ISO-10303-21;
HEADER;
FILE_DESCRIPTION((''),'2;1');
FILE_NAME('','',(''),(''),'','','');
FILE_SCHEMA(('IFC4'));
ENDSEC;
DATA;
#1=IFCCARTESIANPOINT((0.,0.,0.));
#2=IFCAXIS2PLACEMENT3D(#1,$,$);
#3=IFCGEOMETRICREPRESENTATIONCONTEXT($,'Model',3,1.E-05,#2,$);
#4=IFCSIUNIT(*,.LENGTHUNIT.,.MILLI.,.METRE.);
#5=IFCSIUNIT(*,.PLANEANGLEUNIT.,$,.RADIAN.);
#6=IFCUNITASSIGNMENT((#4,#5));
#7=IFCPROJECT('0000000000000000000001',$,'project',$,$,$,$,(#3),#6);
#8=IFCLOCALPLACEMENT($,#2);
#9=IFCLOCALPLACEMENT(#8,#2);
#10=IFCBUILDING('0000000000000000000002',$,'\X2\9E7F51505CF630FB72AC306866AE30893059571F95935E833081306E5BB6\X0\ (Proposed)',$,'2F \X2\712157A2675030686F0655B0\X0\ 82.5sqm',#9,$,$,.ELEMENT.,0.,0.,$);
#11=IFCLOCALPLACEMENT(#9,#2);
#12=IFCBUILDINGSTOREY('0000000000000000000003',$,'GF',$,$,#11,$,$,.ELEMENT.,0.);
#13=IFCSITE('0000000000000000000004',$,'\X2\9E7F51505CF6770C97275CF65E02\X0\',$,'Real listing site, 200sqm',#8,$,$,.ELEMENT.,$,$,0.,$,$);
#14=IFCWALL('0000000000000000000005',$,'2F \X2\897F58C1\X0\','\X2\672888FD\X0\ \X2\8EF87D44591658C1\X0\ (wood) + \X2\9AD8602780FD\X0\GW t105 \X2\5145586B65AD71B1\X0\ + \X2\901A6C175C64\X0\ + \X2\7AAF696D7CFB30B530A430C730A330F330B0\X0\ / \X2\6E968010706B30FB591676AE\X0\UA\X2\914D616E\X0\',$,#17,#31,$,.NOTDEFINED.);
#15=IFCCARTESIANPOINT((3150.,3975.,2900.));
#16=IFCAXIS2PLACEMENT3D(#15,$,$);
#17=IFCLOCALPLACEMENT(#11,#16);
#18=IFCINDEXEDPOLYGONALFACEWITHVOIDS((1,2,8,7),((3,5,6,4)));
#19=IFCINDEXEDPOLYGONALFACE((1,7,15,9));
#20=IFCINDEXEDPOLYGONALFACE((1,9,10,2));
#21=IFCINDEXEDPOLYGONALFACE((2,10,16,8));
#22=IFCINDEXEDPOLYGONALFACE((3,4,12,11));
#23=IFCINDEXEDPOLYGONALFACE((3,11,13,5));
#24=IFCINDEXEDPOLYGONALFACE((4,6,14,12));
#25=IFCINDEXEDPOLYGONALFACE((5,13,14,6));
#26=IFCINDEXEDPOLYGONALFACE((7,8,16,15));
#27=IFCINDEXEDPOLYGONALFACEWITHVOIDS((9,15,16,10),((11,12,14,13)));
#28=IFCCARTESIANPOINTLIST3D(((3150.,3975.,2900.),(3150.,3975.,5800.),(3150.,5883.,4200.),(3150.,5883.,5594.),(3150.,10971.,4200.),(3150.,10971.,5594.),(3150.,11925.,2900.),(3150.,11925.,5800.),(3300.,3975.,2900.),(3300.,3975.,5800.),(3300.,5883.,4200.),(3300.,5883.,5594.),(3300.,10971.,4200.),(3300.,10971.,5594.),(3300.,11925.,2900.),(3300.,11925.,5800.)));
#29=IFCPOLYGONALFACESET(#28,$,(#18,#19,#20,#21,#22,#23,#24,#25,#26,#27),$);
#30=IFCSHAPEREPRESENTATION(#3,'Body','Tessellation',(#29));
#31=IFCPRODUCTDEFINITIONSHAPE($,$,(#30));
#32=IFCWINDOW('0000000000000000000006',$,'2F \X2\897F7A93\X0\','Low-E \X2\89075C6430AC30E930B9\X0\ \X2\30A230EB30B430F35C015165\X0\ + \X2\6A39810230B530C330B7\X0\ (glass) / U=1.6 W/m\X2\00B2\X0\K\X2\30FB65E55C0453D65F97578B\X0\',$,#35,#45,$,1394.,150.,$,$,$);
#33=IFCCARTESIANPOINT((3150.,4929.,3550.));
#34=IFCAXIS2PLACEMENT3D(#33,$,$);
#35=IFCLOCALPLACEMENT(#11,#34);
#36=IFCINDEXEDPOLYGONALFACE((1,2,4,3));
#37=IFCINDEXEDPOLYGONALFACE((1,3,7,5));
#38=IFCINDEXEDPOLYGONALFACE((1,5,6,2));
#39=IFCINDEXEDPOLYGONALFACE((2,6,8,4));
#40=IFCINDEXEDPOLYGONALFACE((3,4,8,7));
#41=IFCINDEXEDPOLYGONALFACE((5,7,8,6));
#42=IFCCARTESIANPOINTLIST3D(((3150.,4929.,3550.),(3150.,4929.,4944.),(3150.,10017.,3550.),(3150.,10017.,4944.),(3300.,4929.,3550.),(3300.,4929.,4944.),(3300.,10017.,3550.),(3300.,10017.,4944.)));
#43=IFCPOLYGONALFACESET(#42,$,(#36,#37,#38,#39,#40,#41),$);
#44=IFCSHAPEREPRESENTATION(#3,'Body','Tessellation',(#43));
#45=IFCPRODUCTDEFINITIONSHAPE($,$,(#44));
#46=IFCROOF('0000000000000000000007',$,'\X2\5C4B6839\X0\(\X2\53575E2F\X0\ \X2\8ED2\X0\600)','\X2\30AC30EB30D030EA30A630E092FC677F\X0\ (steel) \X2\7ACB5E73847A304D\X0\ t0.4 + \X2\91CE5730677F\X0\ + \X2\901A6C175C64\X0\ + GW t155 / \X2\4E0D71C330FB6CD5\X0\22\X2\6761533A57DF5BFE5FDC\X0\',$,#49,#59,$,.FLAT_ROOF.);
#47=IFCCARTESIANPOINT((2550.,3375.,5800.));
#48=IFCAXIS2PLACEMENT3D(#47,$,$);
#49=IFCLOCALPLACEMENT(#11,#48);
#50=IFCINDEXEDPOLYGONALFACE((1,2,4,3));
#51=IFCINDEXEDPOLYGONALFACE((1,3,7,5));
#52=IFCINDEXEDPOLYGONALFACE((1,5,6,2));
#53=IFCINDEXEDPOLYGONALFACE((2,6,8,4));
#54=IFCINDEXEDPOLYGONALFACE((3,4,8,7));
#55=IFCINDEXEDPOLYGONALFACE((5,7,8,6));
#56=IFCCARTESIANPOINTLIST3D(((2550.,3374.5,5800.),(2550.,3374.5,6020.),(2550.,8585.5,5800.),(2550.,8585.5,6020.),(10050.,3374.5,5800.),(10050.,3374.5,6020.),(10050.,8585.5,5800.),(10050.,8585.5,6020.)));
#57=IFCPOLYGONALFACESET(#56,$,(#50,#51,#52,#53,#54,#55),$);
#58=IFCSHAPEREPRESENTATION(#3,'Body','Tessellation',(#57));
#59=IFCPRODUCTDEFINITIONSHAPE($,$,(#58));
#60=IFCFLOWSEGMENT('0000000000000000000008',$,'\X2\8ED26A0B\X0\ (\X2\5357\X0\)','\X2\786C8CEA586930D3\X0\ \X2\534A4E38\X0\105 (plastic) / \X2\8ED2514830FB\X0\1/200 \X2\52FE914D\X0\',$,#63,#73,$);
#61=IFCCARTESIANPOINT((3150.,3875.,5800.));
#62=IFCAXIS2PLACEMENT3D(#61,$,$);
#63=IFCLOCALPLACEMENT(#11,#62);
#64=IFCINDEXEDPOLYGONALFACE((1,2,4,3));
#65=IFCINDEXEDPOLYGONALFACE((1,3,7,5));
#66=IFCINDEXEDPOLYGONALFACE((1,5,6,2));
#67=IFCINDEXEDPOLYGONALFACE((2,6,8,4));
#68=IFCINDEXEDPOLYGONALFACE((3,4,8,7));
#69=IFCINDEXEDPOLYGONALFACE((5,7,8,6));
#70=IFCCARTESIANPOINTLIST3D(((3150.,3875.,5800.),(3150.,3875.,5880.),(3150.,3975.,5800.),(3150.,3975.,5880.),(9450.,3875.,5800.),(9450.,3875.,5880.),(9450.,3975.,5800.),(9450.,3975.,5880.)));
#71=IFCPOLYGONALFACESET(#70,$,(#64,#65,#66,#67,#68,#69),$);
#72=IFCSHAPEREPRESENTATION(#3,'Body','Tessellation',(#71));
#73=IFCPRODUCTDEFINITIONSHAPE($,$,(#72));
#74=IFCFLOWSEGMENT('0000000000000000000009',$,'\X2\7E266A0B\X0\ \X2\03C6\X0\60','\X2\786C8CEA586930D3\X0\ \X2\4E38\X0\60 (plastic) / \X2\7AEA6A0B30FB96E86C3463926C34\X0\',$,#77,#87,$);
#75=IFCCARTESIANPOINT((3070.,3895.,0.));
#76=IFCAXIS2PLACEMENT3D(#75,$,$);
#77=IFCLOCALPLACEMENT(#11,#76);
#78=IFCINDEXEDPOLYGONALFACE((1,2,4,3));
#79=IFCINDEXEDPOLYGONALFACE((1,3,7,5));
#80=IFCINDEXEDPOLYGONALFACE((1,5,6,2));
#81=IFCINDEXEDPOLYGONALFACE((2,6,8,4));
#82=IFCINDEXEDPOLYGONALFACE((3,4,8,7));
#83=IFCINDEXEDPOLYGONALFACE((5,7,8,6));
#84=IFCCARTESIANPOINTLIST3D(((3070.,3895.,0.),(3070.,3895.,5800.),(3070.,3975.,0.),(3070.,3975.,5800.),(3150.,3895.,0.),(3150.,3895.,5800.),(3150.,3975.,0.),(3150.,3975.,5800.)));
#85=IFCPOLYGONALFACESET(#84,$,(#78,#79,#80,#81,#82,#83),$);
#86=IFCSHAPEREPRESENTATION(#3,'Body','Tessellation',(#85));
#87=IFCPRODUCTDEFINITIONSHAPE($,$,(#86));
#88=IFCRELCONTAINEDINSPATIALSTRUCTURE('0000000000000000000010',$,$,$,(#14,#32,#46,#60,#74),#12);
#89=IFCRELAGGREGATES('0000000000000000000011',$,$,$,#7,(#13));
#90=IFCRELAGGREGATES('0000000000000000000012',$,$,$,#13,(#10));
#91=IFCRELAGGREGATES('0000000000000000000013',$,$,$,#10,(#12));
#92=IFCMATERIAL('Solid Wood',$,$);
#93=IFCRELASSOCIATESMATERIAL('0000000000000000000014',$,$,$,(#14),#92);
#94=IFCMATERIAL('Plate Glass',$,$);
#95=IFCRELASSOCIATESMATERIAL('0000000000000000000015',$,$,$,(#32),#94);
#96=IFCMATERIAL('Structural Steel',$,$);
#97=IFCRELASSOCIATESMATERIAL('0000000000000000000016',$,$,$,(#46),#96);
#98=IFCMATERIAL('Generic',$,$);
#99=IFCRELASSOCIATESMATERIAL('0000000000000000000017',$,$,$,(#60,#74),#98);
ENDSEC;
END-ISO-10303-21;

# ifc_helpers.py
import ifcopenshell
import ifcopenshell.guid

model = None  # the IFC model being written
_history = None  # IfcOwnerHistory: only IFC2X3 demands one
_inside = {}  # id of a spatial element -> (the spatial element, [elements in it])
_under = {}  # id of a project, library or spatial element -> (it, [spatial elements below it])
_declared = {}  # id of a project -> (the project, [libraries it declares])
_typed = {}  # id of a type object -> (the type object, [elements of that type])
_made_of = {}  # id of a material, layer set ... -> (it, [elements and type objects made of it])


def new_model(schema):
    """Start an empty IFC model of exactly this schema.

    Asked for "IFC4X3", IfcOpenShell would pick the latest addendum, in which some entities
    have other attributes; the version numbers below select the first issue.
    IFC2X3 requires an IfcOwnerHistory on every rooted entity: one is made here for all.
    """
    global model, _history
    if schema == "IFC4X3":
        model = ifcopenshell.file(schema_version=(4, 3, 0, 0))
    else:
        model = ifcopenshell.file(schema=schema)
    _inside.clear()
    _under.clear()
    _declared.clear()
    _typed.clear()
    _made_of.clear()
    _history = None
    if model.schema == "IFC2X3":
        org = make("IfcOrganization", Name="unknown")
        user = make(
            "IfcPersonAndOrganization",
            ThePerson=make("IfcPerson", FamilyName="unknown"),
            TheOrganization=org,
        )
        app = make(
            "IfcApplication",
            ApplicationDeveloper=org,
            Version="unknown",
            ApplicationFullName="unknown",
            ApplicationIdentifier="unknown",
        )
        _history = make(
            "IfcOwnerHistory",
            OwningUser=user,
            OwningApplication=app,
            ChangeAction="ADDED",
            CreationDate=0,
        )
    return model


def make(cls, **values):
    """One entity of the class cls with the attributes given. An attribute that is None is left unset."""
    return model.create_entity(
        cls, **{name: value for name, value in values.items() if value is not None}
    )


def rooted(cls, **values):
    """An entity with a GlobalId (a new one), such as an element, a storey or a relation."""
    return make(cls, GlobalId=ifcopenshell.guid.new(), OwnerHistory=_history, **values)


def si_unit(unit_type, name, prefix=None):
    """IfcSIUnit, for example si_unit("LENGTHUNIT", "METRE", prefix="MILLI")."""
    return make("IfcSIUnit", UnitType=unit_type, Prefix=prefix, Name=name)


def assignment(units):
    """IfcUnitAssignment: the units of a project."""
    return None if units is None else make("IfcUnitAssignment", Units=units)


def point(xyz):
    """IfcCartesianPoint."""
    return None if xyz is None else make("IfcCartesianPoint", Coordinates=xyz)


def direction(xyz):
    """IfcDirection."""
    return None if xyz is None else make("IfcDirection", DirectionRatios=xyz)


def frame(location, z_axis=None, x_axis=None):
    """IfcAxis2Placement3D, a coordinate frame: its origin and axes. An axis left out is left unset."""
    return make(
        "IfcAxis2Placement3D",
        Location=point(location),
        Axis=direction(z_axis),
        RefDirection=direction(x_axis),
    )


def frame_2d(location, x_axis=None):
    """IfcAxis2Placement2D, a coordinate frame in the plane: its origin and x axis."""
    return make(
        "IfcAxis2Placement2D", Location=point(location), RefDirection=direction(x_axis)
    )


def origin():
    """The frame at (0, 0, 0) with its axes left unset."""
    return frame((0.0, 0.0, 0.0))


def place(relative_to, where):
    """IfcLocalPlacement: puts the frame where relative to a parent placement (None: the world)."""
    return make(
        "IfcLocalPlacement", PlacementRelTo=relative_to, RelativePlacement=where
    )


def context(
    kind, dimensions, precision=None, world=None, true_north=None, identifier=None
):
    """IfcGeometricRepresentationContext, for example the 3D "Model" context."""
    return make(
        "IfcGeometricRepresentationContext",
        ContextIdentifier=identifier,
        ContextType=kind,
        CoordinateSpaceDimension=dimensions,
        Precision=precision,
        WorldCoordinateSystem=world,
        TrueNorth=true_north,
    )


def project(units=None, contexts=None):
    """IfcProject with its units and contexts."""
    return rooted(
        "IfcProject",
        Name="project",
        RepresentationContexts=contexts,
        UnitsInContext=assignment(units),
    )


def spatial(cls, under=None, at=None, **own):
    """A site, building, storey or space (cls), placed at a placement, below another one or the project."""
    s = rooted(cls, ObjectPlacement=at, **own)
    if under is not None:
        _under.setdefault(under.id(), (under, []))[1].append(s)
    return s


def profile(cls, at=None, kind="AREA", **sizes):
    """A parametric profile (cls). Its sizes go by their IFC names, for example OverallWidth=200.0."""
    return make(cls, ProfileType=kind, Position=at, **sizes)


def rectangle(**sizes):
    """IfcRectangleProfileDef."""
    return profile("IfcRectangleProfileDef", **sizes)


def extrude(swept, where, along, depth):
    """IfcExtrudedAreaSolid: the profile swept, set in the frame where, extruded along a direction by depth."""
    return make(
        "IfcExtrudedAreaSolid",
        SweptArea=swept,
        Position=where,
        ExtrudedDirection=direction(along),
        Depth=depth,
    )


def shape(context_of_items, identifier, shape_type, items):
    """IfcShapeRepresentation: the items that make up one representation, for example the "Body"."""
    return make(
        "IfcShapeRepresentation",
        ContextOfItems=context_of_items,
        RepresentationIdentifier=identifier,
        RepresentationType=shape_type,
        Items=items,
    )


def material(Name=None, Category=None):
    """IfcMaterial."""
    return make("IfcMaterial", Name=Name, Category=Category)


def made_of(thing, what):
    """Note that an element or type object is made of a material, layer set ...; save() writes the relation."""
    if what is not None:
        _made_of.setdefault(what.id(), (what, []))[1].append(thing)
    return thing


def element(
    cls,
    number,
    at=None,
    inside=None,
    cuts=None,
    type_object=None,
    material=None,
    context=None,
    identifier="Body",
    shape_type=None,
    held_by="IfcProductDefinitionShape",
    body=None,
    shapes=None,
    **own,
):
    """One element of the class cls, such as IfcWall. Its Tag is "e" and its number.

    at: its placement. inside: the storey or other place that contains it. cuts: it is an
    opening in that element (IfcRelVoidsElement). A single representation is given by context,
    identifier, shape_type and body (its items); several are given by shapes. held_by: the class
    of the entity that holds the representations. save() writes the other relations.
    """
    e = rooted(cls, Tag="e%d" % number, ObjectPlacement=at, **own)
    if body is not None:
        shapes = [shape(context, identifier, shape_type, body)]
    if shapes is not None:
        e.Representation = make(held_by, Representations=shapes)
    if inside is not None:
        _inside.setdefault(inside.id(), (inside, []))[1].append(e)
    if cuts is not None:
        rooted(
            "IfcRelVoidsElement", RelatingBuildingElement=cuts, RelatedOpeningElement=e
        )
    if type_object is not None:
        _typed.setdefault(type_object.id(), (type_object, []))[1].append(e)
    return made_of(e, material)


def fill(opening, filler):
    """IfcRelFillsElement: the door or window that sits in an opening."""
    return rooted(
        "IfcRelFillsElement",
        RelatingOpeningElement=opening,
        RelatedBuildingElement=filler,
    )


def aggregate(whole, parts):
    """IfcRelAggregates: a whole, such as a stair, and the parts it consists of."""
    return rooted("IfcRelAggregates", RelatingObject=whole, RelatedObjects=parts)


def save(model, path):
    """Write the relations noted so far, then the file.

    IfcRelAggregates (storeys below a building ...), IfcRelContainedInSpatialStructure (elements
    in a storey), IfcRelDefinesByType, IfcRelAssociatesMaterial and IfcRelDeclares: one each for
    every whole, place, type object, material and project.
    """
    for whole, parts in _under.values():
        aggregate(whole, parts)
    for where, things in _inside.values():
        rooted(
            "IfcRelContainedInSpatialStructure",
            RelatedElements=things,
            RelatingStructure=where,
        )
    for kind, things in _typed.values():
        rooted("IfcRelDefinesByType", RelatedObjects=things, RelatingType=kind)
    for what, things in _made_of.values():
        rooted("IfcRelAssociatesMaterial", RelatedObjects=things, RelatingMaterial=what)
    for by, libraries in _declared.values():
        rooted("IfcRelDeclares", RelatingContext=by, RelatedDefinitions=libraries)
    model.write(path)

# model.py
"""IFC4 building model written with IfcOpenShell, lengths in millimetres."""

from ifc_helpers import new_model, si_unit, frame, frame_2d, origin, place, context, project, spatial, rectangle, extrude, material, element, fill, save


model = new_model("IFC4")

# Units and contexts
model_context = context("Model", 3, precision=1e-05, world=origin())
ifc_project = project(units=[si_unit("LENGTHUNIT", "METRE", prefix="MILLI"), si_unit("PLANEANGLEUNIT", "RADIAN")], contexts=[model_context])

# Site, building, storey
site_placement = place(None, origin())
site = spatial("IfcSite", under=ifc_project, at=site_placement, Name="鹿児島県霧島市", ObjectType="Real listing site, 200sqm", CompositionType="ELEMENT", RefElevation=0.0)
building_placement = place(site_placement, origin())
building = spatial("IfcBuilding", under=site, at=building_placement, Name="鹿児島・犬と暮らす土間広めの家 (Proposed)", ObjectType="2F 無垢材と漆喰 82.5sqm", CompositionType="ELEMENT", ElevationOfRefHeight=0.0, ElevationOfTerrain=0.0)
storey_placement = place(building_placement, origin())
storey = spatial("IfcBuildingStorey", under=building, at=storey_placement, Name="GF", CompositionType="ELEMENT", Elevation=0.0)

# Shared definitions
ifc_material_1 = material(Name="Solid Wood")

# Shared definitions
ifc_material_2 = material(Name="Plate Glass")

# Wall, opening, window
wall_1_placement = place(storey_placement, frame((3150.0, 3975.0, 2900.0)))
wall_1 = element("IfcWall", 1, at=wall_1_placement, inside=storey, material=ifc_material_1, Name="2F 西壁", Description="木製 軸組外壁 (wood) + 高性能GW t105 充填断熱 + 通気層 + 窯業系サイディング / 準耐火・外皮UA配慮", PredefinedType="NOTDEFINED", context=model_context, shape_type="SweptSolid", body=[
    extrude(rectangle(XDim=150.0, YDim=7950.0, at=frame_2d((75.0, 3975.0))), frame((3150.0, 3975.0, 2900.0)), (0.0, 0.0, 1.0), 2900.0),
])
opening_1_placement = place(storey_placement, frame((3150.0, 4929.0, 3550.0)))
opening_1 = element("IfcOpeningElement", 2, at=opening_1_placement, cuts=wall_1, PredefinedType="NOTDEFINED", context=model_context, shape_type="SweptSolid", body=[
    extrude(rectangle(XDim=150.0, YDim=5088.0, at=frame_2d((75.0, 2544.0))), frame((3150.0, 4929.0, 3550.0)), (0.0, 0.0, 1.0), 1394.0),
])
window_1_placement = place(storey_placement, frame((3150.0, 4929.0, 3550.0)))
window_1 = element("IfcWindow", 3, at=window_1_placement, inside=storey, material=ifc_material_2, Name="2F 西窓", Description="Low-E 複層ガラス アルゴン封入 + 樹脂サッシ (glass) / U=1.6 W/m²K・日射取得型", OverallHeight=1394.0, OverallWidth=150.0, context=model_context, shape_type="SweptSolid", body=[
    extrude(rectangle(XDim=150.0, YDim=5088.0, at=frame_2d((75.0, 2544.0))), frame((3150.0, 4929.0, 3550.0)), (0.0, 0.0, 1.0), 1394.0),
])
fill(opening_1, window_1)

# Roof
ifc_material_3 = material(Name="Structural Steel")
for number, where, name in (
    (4, (2550.0, 3375.0, 5800.0), "屋根(南帯 軒600)"),
):
    element("IfcRoof", number, at=place(storey_placement, frame(where)), inside=storey, material=ifc_material_3, Name=name, Description="ガルバリウム鋼板 (steel) 立平葺き t0.4 + 野地板 + 通気層 + GW t155 / 不燃・法22条区域対応", PredefinedType="FLAT_ROOF", context=model_context, shape_type="SweptSolid", body=[
        extrude(rectangle(XDim=7500.0, YDim=5211.0, at=frame_2d((3750.0, 2605.0))), frame((2550.0, 3375.0, 5800.0)), (0.0, 0.0, 1.0), 220.0),
    ])

# Flow segments
ifc_material_4 = material(Name="Generic")
flow_segment_1_placement = place(storey_placement, frame((3150.0, 3875.0, 5800.0)))
element("IfcFlowSegment", 5, at=flow_segment_1_placement, inside=storey, material=ifc_material_4, Name="軒樋 (南)", Description="硬質塩ビ 半丸105 (plastic) / 軒先・1/200 勾配", context=model_context, shape_type="SweptSolid", body=[
    extrude(rectangle(XDim=6300.0, YDim=100.0, at=frame_2d((3150.0, 50.0))), frame((3150.0, 3875.0, 5800.0)), (0.0, 0.0, 1.0), 80.0),
])
flow_segment_2_placement = place(storey_placement, frame((3070.0, 3895.0, 0.0)))
element("IfcFlowSegment", 6, at=flow_segment_2_placement, inside=storey, material=ifc_material_4, Name="縦樋 φ60", Description="硬質塩ビ 丸60 (plastic) / 竪樋・雨水排水", context=model_context, shape_type="SweptSolid", body=[
    extrude(rectangle(XDim=80.0, YDim=80.0, at=frame_2d((40.0, 40.0))), frame((3070.0, 3895.0, 0.0)), (0.0, 0.0, 1.0), 5800.0),
])

save(model, "model.ifc")
